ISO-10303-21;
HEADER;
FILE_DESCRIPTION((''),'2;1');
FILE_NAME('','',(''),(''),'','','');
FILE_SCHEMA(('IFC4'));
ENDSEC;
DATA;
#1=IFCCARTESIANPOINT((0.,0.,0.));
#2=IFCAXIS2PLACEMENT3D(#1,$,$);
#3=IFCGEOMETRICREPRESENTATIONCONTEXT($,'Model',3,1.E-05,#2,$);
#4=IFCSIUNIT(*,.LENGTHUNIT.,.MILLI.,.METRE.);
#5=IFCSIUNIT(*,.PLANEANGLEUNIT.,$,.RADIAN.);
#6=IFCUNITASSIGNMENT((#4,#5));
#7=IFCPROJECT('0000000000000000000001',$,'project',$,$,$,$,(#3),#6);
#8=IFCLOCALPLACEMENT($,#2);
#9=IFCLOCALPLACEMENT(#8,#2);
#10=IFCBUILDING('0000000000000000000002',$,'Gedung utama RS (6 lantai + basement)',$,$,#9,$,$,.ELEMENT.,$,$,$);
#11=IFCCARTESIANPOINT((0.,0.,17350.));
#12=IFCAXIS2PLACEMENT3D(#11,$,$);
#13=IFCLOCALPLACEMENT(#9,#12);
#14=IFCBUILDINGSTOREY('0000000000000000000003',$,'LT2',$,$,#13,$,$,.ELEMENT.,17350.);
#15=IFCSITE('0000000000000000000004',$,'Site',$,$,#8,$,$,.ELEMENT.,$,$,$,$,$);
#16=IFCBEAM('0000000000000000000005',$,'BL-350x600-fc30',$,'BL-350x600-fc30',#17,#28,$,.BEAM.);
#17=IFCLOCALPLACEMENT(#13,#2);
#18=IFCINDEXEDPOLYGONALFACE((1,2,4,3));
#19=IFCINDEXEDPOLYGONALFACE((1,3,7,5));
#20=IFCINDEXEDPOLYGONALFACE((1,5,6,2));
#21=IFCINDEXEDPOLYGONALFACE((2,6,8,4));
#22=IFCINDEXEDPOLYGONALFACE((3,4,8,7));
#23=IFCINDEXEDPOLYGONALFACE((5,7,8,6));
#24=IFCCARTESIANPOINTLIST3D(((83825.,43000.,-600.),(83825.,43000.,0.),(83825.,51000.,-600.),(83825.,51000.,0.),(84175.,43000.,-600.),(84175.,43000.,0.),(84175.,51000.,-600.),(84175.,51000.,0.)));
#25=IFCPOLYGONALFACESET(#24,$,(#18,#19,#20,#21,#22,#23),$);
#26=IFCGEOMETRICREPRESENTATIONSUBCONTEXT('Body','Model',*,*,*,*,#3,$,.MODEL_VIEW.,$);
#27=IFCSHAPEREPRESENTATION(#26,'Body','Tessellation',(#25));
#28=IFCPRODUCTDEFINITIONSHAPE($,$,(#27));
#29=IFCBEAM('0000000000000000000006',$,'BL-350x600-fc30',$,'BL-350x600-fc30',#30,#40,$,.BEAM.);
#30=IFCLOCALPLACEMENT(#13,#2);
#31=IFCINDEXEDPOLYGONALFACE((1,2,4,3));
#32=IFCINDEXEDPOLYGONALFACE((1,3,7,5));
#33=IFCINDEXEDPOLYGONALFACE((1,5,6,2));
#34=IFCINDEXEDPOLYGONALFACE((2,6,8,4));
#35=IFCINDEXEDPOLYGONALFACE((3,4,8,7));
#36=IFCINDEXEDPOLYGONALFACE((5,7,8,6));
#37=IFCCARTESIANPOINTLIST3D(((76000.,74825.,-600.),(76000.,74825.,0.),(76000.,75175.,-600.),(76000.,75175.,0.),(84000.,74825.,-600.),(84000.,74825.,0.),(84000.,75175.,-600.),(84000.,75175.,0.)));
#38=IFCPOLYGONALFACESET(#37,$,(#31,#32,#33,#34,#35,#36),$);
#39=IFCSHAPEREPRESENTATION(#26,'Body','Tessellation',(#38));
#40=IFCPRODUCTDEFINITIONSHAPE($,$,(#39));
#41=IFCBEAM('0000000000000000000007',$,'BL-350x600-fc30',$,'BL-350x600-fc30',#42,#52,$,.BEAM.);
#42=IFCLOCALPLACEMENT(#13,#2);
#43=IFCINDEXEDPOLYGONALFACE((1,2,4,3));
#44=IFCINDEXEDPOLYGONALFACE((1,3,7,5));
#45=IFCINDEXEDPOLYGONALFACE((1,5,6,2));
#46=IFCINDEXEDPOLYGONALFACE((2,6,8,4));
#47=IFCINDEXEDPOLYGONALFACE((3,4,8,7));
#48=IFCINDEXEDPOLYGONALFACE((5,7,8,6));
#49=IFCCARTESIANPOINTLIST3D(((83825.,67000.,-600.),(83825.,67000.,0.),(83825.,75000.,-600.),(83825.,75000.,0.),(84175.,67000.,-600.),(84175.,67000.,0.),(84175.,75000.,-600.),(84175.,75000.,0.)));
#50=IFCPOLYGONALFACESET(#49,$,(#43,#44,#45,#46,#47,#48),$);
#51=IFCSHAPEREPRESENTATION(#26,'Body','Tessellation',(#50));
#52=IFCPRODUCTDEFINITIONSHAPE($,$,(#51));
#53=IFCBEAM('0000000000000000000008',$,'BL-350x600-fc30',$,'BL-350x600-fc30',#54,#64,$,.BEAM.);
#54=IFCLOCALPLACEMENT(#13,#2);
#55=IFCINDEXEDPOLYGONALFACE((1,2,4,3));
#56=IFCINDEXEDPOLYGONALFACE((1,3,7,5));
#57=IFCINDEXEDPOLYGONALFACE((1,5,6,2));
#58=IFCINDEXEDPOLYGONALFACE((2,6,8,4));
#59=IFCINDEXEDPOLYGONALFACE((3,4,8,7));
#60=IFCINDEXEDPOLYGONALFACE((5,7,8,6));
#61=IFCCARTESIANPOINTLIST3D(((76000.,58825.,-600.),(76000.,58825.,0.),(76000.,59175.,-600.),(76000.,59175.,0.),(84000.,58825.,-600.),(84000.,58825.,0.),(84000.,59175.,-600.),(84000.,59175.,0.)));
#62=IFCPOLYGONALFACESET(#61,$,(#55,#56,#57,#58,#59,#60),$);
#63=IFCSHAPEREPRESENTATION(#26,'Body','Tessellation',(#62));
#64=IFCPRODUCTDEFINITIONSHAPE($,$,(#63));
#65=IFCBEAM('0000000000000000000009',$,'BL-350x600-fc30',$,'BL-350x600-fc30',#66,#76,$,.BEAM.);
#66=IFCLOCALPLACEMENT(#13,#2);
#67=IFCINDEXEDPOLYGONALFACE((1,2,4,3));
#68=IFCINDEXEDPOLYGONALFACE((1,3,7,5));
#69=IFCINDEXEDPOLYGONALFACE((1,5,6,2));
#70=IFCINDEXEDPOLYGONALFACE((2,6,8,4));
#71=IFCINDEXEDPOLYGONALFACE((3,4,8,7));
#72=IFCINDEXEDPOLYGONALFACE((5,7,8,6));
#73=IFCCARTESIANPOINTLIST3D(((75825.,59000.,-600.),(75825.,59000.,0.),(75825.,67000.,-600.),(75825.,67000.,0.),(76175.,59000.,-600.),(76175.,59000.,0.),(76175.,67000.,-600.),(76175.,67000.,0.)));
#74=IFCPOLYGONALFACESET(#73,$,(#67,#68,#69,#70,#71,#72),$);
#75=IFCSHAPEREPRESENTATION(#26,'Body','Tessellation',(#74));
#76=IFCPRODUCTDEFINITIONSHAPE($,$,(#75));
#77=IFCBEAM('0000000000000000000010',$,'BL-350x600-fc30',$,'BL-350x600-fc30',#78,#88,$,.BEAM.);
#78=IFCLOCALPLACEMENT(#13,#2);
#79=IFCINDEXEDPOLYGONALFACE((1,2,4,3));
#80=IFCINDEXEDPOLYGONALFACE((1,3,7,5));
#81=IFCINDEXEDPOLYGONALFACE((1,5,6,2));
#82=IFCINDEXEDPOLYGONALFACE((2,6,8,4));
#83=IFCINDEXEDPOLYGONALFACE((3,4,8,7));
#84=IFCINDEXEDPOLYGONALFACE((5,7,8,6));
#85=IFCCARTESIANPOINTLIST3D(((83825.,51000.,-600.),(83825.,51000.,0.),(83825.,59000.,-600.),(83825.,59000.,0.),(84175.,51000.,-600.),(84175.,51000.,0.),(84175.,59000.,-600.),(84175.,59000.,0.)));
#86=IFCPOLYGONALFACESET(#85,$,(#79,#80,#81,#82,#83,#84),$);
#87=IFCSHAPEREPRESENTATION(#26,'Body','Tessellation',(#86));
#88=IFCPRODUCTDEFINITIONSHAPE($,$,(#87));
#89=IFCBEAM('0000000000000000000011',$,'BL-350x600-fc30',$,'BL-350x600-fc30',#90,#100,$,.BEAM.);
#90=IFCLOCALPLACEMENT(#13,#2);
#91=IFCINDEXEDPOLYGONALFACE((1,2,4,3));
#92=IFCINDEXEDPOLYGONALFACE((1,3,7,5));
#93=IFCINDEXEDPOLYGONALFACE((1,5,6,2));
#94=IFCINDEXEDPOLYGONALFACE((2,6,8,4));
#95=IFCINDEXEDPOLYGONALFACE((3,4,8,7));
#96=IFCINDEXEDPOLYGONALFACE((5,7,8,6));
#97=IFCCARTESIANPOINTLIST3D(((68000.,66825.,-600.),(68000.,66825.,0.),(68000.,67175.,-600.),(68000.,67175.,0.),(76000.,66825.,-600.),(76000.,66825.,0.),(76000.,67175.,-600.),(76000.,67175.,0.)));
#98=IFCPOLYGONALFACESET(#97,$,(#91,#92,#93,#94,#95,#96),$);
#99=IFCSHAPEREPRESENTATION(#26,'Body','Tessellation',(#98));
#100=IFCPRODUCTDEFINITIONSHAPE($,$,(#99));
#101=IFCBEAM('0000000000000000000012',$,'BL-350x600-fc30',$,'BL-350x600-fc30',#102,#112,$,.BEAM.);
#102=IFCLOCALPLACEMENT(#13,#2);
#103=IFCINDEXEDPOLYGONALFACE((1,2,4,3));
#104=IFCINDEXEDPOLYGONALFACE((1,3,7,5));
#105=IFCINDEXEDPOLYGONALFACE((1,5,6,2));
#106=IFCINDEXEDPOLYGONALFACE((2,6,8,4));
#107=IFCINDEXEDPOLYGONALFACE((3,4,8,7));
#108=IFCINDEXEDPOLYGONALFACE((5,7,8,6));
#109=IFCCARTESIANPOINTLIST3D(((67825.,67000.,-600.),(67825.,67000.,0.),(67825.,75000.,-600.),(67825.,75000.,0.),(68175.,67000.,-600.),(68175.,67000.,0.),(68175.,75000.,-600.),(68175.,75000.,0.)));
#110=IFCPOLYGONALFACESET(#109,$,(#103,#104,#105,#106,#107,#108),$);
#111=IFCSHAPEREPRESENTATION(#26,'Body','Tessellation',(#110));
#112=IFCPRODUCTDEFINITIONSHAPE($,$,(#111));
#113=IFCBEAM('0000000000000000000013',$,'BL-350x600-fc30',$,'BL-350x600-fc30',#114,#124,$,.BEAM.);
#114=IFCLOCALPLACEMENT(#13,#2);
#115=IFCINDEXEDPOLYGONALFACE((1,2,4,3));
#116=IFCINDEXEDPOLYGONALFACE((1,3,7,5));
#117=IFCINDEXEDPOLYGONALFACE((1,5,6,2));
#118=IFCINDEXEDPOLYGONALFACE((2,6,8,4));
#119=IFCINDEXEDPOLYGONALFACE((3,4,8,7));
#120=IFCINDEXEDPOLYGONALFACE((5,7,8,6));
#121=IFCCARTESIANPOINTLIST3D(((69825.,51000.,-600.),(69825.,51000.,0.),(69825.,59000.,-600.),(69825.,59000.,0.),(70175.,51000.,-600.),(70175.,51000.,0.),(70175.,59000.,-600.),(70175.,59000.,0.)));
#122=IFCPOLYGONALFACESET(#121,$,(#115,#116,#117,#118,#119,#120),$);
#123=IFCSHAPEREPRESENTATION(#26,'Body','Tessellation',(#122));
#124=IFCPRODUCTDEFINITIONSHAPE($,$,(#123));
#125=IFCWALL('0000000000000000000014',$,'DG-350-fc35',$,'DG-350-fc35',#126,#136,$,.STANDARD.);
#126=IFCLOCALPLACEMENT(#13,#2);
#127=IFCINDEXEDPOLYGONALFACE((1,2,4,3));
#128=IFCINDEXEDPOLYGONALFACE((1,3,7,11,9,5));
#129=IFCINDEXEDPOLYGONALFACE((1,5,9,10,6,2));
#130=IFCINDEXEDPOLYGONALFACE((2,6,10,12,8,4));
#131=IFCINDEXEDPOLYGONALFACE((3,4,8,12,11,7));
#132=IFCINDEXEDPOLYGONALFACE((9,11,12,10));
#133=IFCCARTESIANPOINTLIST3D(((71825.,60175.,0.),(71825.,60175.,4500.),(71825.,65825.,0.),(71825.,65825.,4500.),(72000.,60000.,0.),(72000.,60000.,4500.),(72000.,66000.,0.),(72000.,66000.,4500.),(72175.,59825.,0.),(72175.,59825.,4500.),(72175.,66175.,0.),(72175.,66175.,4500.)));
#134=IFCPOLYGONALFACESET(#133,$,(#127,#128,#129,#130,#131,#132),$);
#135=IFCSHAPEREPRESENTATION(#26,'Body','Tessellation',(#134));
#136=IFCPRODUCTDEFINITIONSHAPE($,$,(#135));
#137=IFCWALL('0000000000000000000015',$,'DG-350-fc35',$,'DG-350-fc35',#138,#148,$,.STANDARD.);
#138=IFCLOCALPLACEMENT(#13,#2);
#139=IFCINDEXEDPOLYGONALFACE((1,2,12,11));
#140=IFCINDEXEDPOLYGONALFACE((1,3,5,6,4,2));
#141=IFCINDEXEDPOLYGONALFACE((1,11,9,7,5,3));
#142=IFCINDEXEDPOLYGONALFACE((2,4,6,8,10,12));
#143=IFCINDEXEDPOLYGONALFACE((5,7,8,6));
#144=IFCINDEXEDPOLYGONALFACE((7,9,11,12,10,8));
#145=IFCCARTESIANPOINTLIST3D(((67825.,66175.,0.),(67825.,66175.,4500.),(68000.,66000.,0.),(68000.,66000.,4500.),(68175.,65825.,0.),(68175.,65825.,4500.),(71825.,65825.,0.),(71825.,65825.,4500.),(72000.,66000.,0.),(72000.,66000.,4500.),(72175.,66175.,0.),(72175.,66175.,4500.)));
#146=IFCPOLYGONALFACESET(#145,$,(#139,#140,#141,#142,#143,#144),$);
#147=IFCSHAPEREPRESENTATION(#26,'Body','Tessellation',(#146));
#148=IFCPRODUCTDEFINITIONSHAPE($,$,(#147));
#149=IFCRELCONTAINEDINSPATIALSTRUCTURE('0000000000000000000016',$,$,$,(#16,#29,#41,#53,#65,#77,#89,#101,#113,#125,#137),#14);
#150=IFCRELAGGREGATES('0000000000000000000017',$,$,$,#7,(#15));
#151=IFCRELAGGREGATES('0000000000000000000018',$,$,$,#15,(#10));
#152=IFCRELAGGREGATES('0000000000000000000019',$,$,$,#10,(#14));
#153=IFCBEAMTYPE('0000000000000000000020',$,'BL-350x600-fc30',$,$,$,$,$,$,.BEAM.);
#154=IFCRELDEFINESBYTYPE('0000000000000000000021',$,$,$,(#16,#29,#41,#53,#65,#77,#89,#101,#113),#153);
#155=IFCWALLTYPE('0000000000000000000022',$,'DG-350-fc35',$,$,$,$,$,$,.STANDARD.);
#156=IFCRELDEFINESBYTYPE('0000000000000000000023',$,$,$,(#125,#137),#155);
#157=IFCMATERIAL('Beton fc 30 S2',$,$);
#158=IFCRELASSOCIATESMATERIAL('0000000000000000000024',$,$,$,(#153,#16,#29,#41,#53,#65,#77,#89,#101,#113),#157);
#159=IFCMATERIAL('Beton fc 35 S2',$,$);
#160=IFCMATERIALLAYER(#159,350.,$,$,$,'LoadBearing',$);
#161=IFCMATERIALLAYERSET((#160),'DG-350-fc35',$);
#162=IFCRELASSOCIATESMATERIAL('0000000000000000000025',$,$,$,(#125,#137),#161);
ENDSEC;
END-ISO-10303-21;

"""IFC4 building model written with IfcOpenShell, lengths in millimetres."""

from ifc_helpers import new_model, si_unit, frame, origin, origin_2d, place, context, subcontext, project, spatial, polyline, rectangle, outline, extrude, material, layer, layer_set, layer_usage, material_profile, profile_set, profile_usage, type_object, element, save


model = new_model("IFC4")

# Units and contexts
model_context = context("Model", 3, precision=1e-05, world=origin())
body_context = subcontext(model_context, "Body", "Model", "MODEL_VIEW")
ifc_project = project(units=[si_unit("LENGTHUNIT", "METRE", prefix="MILLI"), si_unit("PLANEANGLEUNIT", "RADIAN")], contexts=[model_context])

# Site, building, storey
site_placement = place(None, origin())
site = spatial("IfcSite", under=ifc_project, at=site_placement, Name="Site", CompositionType="ELEMENT")
building_placement = place(site_placement, origin())
building = spatial("IfcBuilding", under=site, at=building_placement, Name="Gedung utama RS (6 lantai + basement)", CompositionType="ELEMENT")
storey_placement = place(building_placement, frame((0.0, 0.0, 17350.0)))
storey = spatial("IfcBuildingStorey", under=building, at=storey_placement, Name="LT2", CompositionType="ELEMENT", Elevation=17350.0)

# Beams
ifc_material_1 = material(Name="Beton fc 30 S2")
ifc_material_profile_1 = material_profile(ifc_material_1, rectangle(XDim=350.0, YDim=600.0, at=origin_2d()), Name="BL-350x600-fc30")
ifc_profile_set_1 = profile_set([ifc_material_profile_1], Name="BL-350x600-fc30")
ifc_profile_usage_1 = profile_usage(ifc_profile_set_1, cardinal=8)
beam_type_1 = type_object("IfcBeamType", Name="BL-350x600-fc30", PredefinedType="BEAM", material=ifc_profile_set_1)
for number, where, name in (
    (1, (84000.0, 43000.0, -300.0), "BL-350x600-fc30"),
):
    element("IfcBeam", number, at=place(storey_placement, frame(where)), inside=storey, type_object=beam_type_1, material=ifc_profile_usage_1, Name=name, ObjectType="BL-350x600-fc30", PredefinedType="BEAM", context=body_context, shape_type="SweptSolid", body=[
        extrude(rectangle(XDim=350.0, YDim=600.0, at=origin_2d()), frame((0.0, 0.0, 0.0), z_axis=(0.0, 1.0, 0.0), x_axis=(-1.0, 0.0, 0.0)), (0.0, 0.0, 1.0), 8000.0),
    ])
beam_1_placement = place(storey_placement, frame((76000.0, 75000.0, -300.0)))
element("IfcBeam", 2, at=beam_1_placement, inside=storey, type_object=beam_type_1, material=ifc_profile_usage_1, Name="BL-350x600-fc30", ObjectType="BL-350x600-fc30", PredefinedType="BEAM", context=body_context, shape_type="SweptSolid", body=[
    extrude(rectangle(XDim=350.0, YDim=600.0, at=origin_2d()), frame((0.0, 0.0, 0.0), z_axis=(1.0, 0.0, 0.0), x_axis=(0.0, 1.0, 0.0)), (0.0, 0.0, 1.0), 8000.0),
])
beam_2_placement = place(storey_placement, frame((84000.0, 67000.0, -300.0)))
element("IfcBeam", 3, at=beam_2_placement, inside=storey, type_object=beam_type_1, material=ifc_profile_usage_1, Name="BL-350x600-fc30", ObjectType="BL-350x600-fc30", PredefinedType="BEAM", context=body_context, shape_type="SweptSolid", body=[
    extrude(rectangle(XDim=350.0, YDim=600.0, at=origin_2d()), frame((0.0, 0.0, 0.0), z_axis=(0.0, 1.0, 0.0), x_axis=(-1.0, 0.0, 0.0)), (0.0, 0.0, 1.0), 8000.0),
])
beam_3_placement = place(storey_placement, frame((76000.0, 59000.0, -300.0)))
element("IfcBeam", 4, at=beam_3_placement, inside=storey, type_object=beam_type_1, material=ifc_profile_usage_1, Name="BL-350x600-fc30", ObjectType="BL-350x600-fc30", PredefinedType="BEAM", context=body_context, shape_type="SweptSolid", body=[
    extrude(rectangle(XDim=350.0, YDim=600.0, at=origin_2d()), frame((0.0, 0.0, 0.0), z_axis=(1.0, 0.0, 0.0), x_axis=(0.0, 1.0, 0.0)), (0.0, 0.0, 1.0), 8000.0),
])
for number, where, name in (
    (5, (76000.0, 59000.0, -300.0), "BL-350x600-fc30"),
    (6, (84000.0, 51000.0, -300.0), "BL-350x600-fc30"),
):
    element("IfcBeam", number, at=place(storey_placement, frame(where)), inside=storey, type_object=beam_type_1, material=ifc_profile_usage_1, Name=name, ObjectType="BL-350x600-fc30", PredefinedType="BEAM", context=body_context, shape_type="SweptSolid", body=[
        extrude(rectangle(XDim=350.0, YDim=600.0, at=origin_2d()), frame((0.0, 0.0, 0.0), z_axis=(0.0, 1.0, 0.0), x_axis=(-1.0, 0.0, 0.0)), (0.0, 0.0, 1.0), 8000.0),
    ])
beam_4_placement = place(storey_placement, frame((68000.0, 67000.0, -300.0)))
element("IfcBeam", 7, at=beam_4_placement, inside=storey, type_object=beam_type_1, material=ifc_profile_usage_1, Name="BL-350x600-fc30", ObjectType="BL-350x600-fc30", PredefinedType="BEAM", context=body_context, shape_type="SweptSolid", body=[
    extrude(rectangle(XDim=350.0, YDim=600.0, at=origin_2d()), frame((0.0, 0.0, 0.0), z_axis=(1.0, 0.0, 0.0), x_axis=(0.0, 1.0, 0.0)), (0.0, 0.0, 1.0), 8000.0),
])
for number, where, name in (
    (8, (68000.0, 67000.0, -300.0), "BL-350x600-fc30"),
    (9, (70000.0, 51000.0, -300.0), "BL-350x600-fc30"),
):
    element("IfcBeam", number, at=place(storey_placement, frame(where)), inside=storey, type_object=beam_type_1, material=ifc_profile_usage_1, Name=name, ObjectType="BL-350x600-fc30", PredefinedType="BEAM", context=body_context, shape_type="SweptSolid", body=[
        extrude(rectangle(XDim=350.0, YDim=600.0, at=origin_2d()), frame((0.0, 0.0, 0.0), z_axis=(0.0, 1.0, 0.0), x_axis=(-1.0, 0.0, 0.0)), (0.0, 0.0, 1.0), 8000.0),
    ])

# Walls
ifc_material_2 = material(Name="Beton fc 35 S2")
ifc_layer = layer(ifc_material_2, 350.0, Category="LoadBearing")
ifc_layer_set = layer_set([ifc_layer], Name="DG-350-fc35")
ifc_layer_usage = layer_usage(ifc_layer_set, "AXIS2", "NEGATIVE", 175.0)
wall_type = type_object("IfcWallType", Name="DG-350-fc35", PredefinedType="STANDARD")
wall_1_placement = place(storey_placement, frame((72000.0, 60000.0, 0.0), z_axis=(0.0, 0.0, 1.0), x_axis=(0.0, 1.0, 0.0)))
element("IfcWall", 10, at=wall_1_placement, inside=storey, type_object=wall_type, material=ifc_layer_usage, Name="DG-350-fc35", ObjectType="DG-350-fc35", PredefinedType="STANDARD", context=body_context, shape_type="SweptSolid", body=[
    extrude(outline(polyline([(-175.0, -175.0), (0.0, 0.0), (175.0, 175.0), (5825.0, 175.0), (6000.0, 0.0), (6175.0, -175.0), (-175.0, -175.0)])), origin(), (0.0, 0.0, 1.0), 4500.0),
])
wall_2_placement = place(storey_placement, frame((72000.0, 66000.0, 0.0), z_axis=(0.0, 0.0, 1.0), x_axis=(-1.0, 0.0, 0.0)))
element("IfcWall", 11, at=wall_2_placement, inside=storey, type_object=wall_type, material=ifc_layer_usage, Name="DG-350-fc35", ObjectType="DG-350-fc35", PredefinedType="STANDARD", context=body_context, shape_type="SweptSolid", body=[
    extrude(outline(polyline([(-175.0, -175.0), (0.0, 0.0), (175.0, 175.0), (3825.0, 175.0), (4000.0, 0.0), (4175.0, -175.0), (-175.0, -175.0)])), origin(), (0.0, 0.0, 1.0), 4500.0),
])

save(model, "model.ifc")
